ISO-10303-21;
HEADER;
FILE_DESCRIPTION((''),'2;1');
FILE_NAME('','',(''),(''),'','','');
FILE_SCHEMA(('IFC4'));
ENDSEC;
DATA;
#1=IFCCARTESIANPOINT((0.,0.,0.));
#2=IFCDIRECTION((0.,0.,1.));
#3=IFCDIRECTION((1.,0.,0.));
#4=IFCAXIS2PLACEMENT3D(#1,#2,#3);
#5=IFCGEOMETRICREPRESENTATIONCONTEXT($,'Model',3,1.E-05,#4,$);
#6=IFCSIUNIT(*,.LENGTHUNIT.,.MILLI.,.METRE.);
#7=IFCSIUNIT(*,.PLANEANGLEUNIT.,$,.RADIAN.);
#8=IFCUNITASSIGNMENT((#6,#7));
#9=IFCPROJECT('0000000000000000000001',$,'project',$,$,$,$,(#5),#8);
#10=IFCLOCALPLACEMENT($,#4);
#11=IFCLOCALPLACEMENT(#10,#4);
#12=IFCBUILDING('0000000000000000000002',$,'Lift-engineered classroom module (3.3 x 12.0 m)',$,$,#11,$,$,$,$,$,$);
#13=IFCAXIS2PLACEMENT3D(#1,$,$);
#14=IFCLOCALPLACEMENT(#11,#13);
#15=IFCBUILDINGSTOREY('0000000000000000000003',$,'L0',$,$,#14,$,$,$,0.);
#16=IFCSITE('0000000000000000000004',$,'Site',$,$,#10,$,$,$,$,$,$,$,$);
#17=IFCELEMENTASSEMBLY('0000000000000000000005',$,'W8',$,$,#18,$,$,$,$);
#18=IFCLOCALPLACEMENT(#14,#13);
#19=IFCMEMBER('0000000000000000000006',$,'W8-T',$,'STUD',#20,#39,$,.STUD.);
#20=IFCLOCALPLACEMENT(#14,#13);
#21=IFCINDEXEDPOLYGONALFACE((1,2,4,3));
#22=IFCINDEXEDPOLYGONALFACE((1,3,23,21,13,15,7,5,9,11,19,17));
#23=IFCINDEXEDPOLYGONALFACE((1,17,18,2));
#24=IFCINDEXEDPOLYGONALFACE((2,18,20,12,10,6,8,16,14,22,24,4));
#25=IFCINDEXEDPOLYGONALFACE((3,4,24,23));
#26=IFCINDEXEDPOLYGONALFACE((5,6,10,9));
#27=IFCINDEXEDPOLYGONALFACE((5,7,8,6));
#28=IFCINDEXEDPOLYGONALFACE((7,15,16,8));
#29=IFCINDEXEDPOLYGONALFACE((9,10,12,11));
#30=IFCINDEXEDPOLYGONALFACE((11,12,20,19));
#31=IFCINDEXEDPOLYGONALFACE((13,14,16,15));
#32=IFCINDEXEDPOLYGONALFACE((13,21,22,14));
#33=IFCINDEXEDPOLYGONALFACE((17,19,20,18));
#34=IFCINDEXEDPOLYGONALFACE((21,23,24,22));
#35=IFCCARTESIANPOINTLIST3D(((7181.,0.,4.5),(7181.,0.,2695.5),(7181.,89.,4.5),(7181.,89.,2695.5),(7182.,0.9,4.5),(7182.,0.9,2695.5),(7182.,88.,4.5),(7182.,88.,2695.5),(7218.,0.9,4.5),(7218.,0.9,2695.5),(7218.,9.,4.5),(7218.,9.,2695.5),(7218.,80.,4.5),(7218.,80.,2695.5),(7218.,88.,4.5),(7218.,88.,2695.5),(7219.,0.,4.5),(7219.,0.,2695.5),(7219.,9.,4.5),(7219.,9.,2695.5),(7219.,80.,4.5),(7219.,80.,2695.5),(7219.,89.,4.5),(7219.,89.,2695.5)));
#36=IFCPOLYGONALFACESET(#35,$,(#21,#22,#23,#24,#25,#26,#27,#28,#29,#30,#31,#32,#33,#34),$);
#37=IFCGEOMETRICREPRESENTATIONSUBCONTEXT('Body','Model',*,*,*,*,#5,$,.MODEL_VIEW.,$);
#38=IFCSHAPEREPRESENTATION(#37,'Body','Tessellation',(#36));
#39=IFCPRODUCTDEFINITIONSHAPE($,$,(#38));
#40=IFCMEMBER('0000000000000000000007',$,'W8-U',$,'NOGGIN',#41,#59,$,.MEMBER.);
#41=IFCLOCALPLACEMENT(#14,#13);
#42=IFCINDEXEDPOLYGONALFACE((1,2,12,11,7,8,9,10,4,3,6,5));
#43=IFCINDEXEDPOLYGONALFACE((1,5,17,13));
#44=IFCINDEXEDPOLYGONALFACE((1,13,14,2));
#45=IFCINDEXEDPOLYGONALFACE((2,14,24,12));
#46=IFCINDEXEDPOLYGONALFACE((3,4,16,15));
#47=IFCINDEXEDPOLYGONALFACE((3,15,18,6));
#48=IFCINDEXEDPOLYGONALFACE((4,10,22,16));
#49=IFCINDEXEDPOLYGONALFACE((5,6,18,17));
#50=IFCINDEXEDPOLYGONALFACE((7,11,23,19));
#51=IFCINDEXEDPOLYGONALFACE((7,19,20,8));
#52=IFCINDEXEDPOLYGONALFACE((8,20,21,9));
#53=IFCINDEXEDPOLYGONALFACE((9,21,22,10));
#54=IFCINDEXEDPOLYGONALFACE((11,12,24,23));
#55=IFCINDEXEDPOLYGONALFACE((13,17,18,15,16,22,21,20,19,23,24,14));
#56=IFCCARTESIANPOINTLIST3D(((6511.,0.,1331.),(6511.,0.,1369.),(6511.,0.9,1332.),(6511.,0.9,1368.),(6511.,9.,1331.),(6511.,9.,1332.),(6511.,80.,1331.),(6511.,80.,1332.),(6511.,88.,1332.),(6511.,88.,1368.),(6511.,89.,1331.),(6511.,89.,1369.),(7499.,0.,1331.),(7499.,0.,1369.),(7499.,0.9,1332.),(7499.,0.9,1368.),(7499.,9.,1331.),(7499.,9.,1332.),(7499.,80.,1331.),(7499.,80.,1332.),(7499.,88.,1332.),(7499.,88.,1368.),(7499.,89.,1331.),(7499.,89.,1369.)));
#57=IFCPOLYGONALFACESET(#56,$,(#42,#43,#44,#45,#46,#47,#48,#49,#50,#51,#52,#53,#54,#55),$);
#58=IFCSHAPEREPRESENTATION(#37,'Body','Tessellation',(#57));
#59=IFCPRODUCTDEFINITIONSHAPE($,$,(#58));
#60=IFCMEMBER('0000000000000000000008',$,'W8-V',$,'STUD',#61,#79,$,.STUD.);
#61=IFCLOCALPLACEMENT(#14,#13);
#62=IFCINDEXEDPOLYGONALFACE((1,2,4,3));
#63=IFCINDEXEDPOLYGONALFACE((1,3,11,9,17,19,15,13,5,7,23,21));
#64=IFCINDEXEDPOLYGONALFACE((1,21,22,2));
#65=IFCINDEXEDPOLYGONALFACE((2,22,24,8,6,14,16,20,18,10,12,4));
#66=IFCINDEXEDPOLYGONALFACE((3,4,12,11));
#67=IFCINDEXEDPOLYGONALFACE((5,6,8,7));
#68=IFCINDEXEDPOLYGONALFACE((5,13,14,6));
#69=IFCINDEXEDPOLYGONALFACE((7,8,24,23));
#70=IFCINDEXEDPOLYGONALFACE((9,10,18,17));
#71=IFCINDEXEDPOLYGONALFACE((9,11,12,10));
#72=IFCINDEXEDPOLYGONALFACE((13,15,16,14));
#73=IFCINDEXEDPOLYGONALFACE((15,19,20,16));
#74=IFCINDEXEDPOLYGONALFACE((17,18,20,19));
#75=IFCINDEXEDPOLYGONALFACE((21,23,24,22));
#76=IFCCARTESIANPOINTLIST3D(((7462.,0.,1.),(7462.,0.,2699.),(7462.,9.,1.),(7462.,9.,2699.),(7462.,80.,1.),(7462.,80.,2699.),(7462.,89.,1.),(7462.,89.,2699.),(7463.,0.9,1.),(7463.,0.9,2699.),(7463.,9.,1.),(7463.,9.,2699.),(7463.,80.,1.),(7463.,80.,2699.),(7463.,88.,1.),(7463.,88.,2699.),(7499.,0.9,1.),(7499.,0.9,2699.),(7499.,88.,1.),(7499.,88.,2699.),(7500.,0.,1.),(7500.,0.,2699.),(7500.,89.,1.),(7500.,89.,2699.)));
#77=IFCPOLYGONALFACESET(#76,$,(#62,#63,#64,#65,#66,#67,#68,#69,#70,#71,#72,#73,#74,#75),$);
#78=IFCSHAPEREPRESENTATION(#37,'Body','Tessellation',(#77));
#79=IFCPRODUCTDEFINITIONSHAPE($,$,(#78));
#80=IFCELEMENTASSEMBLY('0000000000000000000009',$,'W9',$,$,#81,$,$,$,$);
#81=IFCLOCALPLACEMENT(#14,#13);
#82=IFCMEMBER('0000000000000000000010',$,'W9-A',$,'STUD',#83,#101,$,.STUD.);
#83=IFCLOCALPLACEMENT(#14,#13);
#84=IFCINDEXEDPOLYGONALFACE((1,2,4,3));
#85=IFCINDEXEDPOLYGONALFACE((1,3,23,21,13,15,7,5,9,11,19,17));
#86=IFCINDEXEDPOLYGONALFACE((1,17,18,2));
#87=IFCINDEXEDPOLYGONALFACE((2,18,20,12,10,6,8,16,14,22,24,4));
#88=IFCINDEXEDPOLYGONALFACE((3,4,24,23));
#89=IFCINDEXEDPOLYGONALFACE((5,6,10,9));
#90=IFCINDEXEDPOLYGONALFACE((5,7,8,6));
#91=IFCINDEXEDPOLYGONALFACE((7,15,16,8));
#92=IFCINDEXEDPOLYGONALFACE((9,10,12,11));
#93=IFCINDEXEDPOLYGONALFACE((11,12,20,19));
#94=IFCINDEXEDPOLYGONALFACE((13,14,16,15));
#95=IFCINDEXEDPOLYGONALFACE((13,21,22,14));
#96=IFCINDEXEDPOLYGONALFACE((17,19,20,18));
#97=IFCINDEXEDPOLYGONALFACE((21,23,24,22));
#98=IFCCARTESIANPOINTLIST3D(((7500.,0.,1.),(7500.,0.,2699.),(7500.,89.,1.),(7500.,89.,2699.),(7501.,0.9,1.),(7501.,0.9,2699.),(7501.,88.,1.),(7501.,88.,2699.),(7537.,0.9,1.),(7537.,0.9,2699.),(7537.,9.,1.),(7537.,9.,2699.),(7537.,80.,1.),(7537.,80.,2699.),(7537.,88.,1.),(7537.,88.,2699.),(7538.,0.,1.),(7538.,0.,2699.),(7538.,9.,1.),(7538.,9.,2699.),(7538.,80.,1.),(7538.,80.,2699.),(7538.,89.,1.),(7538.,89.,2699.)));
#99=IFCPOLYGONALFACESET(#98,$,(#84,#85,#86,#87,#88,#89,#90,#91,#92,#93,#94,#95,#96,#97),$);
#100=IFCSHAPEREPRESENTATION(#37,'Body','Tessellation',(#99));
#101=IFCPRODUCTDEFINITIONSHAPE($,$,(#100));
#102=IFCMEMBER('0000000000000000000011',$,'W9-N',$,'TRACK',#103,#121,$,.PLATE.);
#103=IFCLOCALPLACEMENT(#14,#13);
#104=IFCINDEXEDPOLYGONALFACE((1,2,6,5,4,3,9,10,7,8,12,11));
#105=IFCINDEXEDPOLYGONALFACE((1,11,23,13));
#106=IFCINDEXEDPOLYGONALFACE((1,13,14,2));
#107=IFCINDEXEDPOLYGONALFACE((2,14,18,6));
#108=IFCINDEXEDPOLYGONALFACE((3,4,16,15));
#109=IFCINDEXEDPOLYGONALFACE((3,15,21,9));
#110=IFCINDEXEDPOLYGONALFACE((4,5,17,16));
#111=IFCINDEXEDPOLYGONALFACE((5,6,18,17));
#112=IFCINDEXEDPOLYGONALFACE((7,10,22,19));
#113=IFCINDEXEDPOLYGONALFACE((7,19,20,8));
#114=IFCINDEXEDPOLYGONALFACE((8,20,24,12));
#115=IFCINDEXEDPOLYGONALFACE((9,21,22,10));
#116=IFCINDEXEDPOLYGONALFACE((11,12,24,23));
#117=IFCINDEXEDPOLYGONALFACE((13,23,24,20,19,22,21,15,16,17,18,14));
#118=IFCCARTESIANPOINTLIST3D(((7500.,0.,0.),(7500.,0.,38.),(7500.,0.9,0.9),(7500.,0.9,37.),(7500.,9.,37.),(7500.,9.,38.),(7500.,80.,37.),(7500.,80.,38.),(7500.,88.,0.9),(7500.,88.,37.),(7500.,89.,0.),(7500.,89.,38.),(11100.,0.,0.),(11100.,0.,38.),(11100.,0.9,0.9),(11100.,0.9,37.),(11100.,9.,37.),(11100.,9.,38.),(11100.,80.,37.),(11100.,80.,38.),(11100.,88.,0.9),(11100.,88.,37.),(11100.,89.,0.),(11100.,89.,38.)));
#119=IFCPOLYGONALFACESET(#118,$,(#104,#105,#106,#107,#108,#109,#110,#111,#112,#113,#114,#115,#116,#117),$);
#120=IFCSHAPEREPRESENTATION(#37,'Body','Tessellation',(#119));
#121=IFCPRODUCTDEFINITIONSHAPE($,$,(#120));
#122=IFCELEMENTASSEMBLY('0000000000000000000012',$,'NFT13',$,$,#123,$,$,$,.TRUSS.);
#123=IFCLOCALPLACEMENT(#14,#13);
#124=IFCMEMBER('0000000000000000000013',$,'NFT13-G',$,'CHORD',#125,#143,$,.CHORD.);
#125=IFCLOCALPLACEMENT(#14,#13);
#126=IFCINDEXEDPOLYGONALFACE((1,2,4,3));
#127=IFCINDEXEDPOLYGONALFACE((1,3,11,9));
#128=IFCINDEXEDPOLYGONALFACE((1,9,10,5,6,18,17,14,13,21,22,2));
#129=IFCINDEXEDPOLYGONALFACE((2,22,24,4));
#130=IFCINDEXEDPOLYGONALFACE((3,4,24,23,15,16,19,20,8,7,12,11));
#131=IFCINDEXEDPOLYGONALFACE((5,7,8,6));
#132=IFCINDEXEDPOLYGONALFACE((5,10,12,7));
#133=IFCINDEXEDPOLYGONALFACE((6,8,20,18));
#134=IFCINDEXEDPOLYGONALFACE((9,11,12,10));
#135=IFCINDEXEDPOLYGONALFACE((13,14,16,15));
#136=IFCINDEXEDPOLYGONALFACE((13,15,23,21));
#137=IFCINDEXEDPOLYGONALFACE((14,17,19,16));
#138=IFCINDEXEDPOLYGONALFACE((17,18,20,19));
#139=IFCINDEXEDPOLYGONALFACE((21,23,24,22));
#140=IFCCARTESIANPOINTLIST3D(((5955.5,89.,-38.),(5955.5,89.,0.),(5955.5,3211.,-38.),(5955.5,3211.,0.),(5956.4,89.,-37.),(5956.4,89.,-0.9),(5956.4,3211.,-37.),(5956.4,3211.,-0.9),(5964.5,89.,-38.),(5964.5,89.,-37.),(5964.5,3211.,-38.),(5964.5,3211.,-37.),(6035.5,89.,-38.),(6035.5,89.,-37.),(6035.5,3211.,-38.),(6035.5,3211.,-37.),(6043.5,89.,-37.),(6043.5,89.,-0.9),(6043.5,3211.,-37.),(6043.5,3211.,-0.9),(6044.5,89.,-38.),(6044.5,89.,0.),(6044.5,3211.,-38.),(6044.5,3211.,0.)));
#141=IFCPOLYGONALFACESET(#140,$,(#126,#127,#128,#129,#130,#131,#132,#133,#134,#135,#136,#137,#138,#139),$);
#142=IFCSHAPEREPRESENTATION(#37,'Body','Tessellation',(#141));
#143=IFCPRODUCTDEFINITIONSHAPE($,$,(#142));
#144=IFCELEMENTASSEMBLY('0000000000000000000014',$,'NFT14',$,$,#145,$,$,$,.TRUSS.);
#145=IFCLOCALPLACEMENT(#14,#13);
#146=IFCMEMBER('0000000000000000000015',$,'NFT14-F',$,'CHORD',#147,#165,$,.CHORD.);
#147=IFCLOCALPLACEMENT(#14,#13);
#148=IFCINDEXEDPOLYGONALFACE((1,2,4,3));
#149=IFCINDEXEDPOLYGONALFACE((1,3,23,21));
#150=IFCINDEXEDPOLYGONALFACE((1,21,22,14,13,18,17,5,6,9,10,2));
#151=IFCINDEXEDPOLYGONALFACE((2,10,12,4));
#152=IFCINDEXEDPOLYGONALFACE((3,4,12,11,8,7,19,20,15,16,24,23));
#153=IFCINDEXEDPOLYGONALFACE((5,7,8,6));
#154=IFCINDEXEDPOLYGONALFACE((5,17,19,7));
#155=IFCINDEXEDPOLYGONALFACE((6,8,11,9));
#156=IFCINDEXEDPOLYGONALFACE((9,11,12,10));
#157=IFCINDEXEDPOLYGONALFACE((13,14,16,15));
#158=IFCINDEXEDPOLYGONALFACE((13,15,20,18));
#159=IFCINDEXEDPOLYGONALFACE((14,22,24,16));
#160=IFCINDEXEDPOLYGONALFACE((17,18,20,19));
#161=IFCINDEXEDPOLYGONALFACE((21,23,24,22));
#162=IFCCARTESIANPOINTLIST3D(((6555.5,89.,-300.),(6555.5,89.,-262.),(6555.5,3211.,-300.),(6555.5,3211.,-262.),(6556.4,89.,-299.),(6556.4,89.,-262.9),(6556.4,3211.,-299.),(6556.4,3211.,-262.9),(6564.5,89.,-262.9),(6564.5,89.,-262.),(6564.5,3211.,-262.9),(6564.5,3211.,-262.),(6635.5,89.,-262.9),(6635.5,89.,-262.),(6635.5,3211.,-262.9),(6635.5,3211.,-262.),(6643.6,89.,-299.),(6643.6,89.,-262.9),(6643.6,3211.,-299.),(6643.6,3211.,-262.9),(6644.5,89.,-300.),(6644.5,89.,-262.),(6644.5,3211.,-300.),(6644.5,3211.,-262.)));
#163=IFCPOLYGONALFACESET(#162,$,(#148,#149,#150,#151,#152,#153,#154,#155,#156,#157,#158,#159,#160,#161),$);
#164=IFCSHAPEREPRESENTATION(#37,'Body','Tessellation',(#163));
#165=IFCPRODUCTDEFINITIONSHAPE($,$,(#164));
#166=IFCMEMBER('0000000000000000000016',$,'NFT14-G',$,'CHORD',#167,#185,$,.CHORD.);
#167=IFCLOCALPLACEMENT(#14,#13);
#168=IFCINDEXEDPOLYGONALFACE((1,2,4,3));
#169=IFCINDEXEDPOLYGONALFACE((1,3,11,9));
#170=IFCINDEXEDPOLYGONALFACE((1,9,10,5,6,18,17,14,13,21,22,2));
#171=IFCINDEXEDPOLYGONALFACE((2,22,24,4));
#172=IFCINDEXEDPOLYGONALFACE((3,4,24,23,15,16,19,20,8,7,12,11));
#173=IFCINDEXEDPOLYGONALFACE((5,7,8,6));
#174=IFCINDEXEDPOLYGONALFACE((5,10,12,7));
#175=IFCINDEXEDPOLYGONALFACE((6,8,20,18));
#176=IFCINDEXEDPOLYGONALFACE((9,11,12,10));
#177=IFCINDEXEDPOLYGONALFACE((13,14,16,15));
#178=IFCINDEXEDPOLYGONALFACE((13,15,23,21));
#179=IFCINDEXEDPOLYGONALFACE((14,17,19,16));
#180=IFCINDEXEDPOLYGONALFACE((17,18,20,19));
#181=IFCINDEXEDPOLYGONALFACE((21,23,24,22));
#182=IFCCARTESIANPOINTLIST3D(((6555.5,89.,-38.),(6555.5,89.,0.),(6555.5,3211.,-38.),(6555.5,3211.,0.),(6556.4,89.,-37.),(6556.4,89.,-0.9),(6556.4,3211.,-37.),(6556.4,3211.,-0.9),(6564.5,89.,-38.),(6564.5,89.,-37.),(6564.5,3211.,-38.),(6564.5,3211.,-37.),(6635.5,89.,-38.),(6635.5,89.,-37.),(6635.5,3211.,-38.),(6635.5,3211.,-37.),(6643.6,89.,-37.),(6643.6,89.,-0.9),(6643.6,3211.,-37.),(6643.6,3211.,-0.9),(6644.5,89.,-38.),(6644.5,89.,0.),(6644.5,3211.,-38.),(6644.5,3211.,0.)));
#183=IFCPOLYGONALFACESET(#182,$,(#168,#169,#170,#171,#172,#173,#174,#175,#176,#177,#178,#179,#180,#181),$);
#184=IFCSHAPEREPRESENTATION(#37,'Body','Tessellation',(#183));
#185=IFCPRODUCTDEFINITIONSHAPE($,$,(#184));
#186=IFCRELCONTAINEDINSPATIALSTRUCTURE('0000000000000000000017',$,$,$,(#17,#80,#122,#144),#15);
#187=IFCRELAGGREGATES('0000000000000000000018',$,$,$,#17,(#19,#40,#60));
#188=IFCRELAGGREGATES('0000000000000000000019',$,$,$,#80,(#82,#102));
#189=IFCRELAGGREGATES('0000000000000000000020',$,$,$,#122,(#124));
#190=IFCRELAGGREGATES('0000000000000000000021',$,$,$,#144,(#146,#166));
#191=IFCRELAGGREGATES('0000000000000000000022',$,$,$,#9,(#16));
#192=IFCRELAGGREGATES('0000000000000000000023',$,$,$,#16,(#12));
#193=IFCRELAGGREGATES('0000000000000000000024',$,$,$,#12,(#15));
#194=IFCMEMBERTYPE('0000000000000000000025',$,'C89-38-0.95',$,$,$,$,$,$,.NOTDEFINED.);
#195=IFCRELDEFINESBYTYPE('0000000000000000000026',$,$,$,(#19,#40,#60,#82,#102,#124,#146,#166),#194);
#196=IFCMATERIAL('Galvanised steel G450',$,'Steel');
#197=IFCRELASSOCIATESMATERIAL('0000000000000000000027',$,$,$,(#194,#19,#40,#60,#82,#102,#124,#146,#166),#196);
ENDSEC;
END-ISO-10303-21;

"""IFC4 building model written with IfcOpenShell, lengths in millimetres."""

from ifc_helpers import new_model, si_unit, frame, origin, origin_with_axes, origin_2d, place, context, subcontext, project, spatial, c_section, extrude, material, material_profile, profile_set, profile_usage, type_object, element, aggregate, save


model = new_model("IFC4")

# Units and contexts
model_context = context("Model", 3, precision=1e-05, world=origin_with_axes())
body_context = subcontext(model_context, "Body", "Model", "MODEL_VIEW")
ifc_project = project(units=[si_unit("LENGTHUNIT", "METRE", prefix="MILLI"), si_unit("PLANEANGLEUNIT", "RADIAN")], contexts=[model_context])

# Site, building, storey
site_placement = place(None, origin_with_axes())
site = spatial("IfcSite", under=ifc_project, at=site_placement, Name="Site")
building_placement = place(site_placement, origin_with_axes())
building = spatial("IfcBuilding", under=site, at=building_placement, Name="Lift-engineered classroom module (3.3 x 12.0 m)")
storey_placement = place(building_placement, origin())
storey = spatial("IfcBuildingStorey", under=building, at=storey_placement, Name="L0", Elevation=0.0)

# Element assemblies, members
assembly_1_placement = place(storey_placement, frame((4500.0, 44.5, 0.0)))
assembly_1 = element("IfcElementAssembly", 1, at=assembly_1_placement, inside=storey, Name="W8")
ifc_material = material(Name="Galvanised steel G450", Category="Steel")
ifc_material_profile = material_profile(ifc_material, c_section(Depth=89.0, Width=38.0, WallThickness=0.9, Girth=9.0, at=origin_2d()), Name="C89-38-0.95")
ifc_profile_set = profile_set([ifc_material_profile], Name="C89-38-0.95")
ifc_profile_usage = profile_usage(ifc_profile_set)
member_type = type_object("IfcMemberType", Name="C89-38-0.95", PredefinedType="NOTDEFINED", material=ifc_profile_set)
member_1_placement = place(assembly_1_placement, frame((2700.0, 0.0, 2695.5), z_axis=(0.0, 0.0, -1.0), x_axis=(1.0, 0.0, 0.0)))
member_1 = element("IfcMember", 2, at=member_1_placement, type_object=member_type, material=ifc_profile_usage, Name="W8-T", ObjectType="STUD", PredefinedType="STUD", context=body_context, shape_type="SweptSolid", body=[
    extrude(c_section(Depth=89.0, Width=38.0, WallThickness=0.9, Girth=9.0, at=origin_2d()), origin(), (0.0, 0.0, 1.0), 2691.0),
])
member_2_placement = place(assembly_1_placement, frame((2999.1, 0.0, 1350.0), z_axis=(-1.0, 0.0, 0.0), x_axis=(0.0, 0.0, -1.0)))
member_2 = element("IfcMember", 3, at=member_2_placement, type_object=member_type, material=ifc_profile_usage, Name="W8-U", ObjectType="NOGGIN", PredefinedType="MEMBER", context=body_context, shape_type="SweptSolid", body=[
    extrude(c_section(Depth=89.0, Width=38.0, WallThickness=0.9, Girth=9.0, at=origin_2d()), origin(), (0.0, 0.0, 1.0), 988.1),
])
member_3_placement = place(assembly_1_placement, frame((2981.0, 0.0, 0.9), z_axis=(0.0, 0.0, 1.0), x_axis=(-1.0, 0.0, 0.0)))
member_3 = element("IfcMember", 4, at=member_3_placement, type_object=member_type, material=ifc_profile_usage, Name="W8-V", ObjectType="STUD", PredefinedType="STUD", context=body_context, shape_type="SweptSolid", body=[
    extrude(c_section(Depth=89.0, Width=38.0, WallThickness=0.9, Girth=9.0, at=origin_2d()), origin(), (0.0, 0.0, 1.0), 2698.1),
])
aggregate(assembly_1, [member_1, member_2, member_3])
assembly_2_placement = place(storey_placement, frame((7500.0, 44.5, 0.0)))
assembly_2 = element("IfcElementAssembly", 5, at=assembly_2_placement, inside=storey, Name="W9")
member_4_placement = place(assembly_2_placement, frame((19.0, 0.0, 2699.1), z_axis=(0.0, 0.0, -1.0), x_axis=(1.0, 0.0, 0.0)))
member_4 = element("IfcMember", 6, at=member_4_placement, type_object=member_type, material=ifc_profile_usage, Name="W9-A", ObjectType="STUD", PredefinedType="STUD", context=body_context, shape_type="SweptSolid", body=[
    extrude(c_section(Depth=89.0, Width=38.0, WallThickness=0.9, Girth=9.0, at=origin_2d()), origin(), (0.0, 0.0, 1.0), 2698.1),
])
member_5_placement = place(assembly_2_placement, frame((0.0, 0.0, 19.0), z_axis=(1.0, 0.0, 0.0), x_axis=(0.0, 0.0, 1.0)))
member_5 = element("IfcMember", 7, at=member_5_placement, type_object=member_type, material=ifc_profile_usage, Name="W9-N", ObjectType="TRACK", PredefinedType="PLATE", context=body_context, shape_type="SweptSolid", body=[
    extrude(c_section(Depth=89.0, Width=38.0, WallThickness=0.9, Girth=9.0, at=origin_2d()), origin(), (0.0, 0.0, 1.0), 3600.0),
])
aggregate(assembly_2, [member_4, member_5])

# Element assembly, member
assembly_3_placement = place(storey_placement, frame((6000.0, 89.0, -300.0)))
assembly_3 = element("IfcElementAssembly", 8, at=assembly_3_placement, inside=storey, Name="NFT13", PredefinedType="TRUSS")
member_6_placement = place(assembly_3_placement, frame((0.0, 0.0, 281.0), z_axis=(0.0, 1.0, 0.0), x_axis=(0.0, 0.0, -1.0)))
member_6 = element("IfcMember", 9, at=member_6_placement, type_object=member_type, material=ifc_profile_usage, Name="NFT13-G", ObjectType="CHORD", PredefinedType="CHORD", context=body_context, shape_type="SweptSolid", body=[
    extrude(c_section(Depth=89.0, Width=38.0, WallThickness=0.9, Girth=9.0, at=origin_2d()), origin(), (0.0, 0.0, 1.0), 3122.0),
])
aggregate(assembly_3, [member_6])

# Element assembly, members
assembly_4_placement = place(storey_placement, frame((6600.0, 89.0, -300.0)))
assembly_4 = element("IfcElementAssembly", 10, at=assembly_4_placement, inside=storey, Name="NFT14", PredefinedType="TRUSS")
member_7_placement = place(assembly_4_placement, frame((0.0, 0.0, 19.0), z_axis=(0.0, 1.0, 0.0), x_axis=(0.0, 0.0, 1.0)))
member_7 = element("IfcMember", 11, at=member_7_placement, type_object=member_type, material=ifc_profile_usage, Name="NFT14-F", ObjectType="CHORD", PredefinedType="CHORD", context=body_context, shape_type="SweptSolid", body=[
    extrude(c_section(Depth=89.0, Width=38.0, WallThickness=0.9, Girth=9.0, at=origin_2d()), origin(), (0.0, 0.0, 1.0), 3122.0),
])
member_8_placement = place(assembly_4_placement, frame((0.0, 0.0, 281.0), z_axis=(0.0, 1.0, 0.0), x_axis=(0.0, 0.0, -1.0)))
member_8 = element("IfcMember", 12, at=member_8_placement, type_object=member_type, material=ifc_profile_usage, Name="NFT14-G", ObjectType="CHORD", PredefinedType="CHORD", context=body_context, shape_type="SweptSolid", body=[
    extrude(c_section(Depth=89.0, Width=38.0, WallThickness=0.9, Girth=9.0, at=origin_2d()), origin(), (0.0, 0.0, 1.0), 3122.0),
])
aggregate(assembly_4, [member_7, member_8])

save(model, "model.ifc")
